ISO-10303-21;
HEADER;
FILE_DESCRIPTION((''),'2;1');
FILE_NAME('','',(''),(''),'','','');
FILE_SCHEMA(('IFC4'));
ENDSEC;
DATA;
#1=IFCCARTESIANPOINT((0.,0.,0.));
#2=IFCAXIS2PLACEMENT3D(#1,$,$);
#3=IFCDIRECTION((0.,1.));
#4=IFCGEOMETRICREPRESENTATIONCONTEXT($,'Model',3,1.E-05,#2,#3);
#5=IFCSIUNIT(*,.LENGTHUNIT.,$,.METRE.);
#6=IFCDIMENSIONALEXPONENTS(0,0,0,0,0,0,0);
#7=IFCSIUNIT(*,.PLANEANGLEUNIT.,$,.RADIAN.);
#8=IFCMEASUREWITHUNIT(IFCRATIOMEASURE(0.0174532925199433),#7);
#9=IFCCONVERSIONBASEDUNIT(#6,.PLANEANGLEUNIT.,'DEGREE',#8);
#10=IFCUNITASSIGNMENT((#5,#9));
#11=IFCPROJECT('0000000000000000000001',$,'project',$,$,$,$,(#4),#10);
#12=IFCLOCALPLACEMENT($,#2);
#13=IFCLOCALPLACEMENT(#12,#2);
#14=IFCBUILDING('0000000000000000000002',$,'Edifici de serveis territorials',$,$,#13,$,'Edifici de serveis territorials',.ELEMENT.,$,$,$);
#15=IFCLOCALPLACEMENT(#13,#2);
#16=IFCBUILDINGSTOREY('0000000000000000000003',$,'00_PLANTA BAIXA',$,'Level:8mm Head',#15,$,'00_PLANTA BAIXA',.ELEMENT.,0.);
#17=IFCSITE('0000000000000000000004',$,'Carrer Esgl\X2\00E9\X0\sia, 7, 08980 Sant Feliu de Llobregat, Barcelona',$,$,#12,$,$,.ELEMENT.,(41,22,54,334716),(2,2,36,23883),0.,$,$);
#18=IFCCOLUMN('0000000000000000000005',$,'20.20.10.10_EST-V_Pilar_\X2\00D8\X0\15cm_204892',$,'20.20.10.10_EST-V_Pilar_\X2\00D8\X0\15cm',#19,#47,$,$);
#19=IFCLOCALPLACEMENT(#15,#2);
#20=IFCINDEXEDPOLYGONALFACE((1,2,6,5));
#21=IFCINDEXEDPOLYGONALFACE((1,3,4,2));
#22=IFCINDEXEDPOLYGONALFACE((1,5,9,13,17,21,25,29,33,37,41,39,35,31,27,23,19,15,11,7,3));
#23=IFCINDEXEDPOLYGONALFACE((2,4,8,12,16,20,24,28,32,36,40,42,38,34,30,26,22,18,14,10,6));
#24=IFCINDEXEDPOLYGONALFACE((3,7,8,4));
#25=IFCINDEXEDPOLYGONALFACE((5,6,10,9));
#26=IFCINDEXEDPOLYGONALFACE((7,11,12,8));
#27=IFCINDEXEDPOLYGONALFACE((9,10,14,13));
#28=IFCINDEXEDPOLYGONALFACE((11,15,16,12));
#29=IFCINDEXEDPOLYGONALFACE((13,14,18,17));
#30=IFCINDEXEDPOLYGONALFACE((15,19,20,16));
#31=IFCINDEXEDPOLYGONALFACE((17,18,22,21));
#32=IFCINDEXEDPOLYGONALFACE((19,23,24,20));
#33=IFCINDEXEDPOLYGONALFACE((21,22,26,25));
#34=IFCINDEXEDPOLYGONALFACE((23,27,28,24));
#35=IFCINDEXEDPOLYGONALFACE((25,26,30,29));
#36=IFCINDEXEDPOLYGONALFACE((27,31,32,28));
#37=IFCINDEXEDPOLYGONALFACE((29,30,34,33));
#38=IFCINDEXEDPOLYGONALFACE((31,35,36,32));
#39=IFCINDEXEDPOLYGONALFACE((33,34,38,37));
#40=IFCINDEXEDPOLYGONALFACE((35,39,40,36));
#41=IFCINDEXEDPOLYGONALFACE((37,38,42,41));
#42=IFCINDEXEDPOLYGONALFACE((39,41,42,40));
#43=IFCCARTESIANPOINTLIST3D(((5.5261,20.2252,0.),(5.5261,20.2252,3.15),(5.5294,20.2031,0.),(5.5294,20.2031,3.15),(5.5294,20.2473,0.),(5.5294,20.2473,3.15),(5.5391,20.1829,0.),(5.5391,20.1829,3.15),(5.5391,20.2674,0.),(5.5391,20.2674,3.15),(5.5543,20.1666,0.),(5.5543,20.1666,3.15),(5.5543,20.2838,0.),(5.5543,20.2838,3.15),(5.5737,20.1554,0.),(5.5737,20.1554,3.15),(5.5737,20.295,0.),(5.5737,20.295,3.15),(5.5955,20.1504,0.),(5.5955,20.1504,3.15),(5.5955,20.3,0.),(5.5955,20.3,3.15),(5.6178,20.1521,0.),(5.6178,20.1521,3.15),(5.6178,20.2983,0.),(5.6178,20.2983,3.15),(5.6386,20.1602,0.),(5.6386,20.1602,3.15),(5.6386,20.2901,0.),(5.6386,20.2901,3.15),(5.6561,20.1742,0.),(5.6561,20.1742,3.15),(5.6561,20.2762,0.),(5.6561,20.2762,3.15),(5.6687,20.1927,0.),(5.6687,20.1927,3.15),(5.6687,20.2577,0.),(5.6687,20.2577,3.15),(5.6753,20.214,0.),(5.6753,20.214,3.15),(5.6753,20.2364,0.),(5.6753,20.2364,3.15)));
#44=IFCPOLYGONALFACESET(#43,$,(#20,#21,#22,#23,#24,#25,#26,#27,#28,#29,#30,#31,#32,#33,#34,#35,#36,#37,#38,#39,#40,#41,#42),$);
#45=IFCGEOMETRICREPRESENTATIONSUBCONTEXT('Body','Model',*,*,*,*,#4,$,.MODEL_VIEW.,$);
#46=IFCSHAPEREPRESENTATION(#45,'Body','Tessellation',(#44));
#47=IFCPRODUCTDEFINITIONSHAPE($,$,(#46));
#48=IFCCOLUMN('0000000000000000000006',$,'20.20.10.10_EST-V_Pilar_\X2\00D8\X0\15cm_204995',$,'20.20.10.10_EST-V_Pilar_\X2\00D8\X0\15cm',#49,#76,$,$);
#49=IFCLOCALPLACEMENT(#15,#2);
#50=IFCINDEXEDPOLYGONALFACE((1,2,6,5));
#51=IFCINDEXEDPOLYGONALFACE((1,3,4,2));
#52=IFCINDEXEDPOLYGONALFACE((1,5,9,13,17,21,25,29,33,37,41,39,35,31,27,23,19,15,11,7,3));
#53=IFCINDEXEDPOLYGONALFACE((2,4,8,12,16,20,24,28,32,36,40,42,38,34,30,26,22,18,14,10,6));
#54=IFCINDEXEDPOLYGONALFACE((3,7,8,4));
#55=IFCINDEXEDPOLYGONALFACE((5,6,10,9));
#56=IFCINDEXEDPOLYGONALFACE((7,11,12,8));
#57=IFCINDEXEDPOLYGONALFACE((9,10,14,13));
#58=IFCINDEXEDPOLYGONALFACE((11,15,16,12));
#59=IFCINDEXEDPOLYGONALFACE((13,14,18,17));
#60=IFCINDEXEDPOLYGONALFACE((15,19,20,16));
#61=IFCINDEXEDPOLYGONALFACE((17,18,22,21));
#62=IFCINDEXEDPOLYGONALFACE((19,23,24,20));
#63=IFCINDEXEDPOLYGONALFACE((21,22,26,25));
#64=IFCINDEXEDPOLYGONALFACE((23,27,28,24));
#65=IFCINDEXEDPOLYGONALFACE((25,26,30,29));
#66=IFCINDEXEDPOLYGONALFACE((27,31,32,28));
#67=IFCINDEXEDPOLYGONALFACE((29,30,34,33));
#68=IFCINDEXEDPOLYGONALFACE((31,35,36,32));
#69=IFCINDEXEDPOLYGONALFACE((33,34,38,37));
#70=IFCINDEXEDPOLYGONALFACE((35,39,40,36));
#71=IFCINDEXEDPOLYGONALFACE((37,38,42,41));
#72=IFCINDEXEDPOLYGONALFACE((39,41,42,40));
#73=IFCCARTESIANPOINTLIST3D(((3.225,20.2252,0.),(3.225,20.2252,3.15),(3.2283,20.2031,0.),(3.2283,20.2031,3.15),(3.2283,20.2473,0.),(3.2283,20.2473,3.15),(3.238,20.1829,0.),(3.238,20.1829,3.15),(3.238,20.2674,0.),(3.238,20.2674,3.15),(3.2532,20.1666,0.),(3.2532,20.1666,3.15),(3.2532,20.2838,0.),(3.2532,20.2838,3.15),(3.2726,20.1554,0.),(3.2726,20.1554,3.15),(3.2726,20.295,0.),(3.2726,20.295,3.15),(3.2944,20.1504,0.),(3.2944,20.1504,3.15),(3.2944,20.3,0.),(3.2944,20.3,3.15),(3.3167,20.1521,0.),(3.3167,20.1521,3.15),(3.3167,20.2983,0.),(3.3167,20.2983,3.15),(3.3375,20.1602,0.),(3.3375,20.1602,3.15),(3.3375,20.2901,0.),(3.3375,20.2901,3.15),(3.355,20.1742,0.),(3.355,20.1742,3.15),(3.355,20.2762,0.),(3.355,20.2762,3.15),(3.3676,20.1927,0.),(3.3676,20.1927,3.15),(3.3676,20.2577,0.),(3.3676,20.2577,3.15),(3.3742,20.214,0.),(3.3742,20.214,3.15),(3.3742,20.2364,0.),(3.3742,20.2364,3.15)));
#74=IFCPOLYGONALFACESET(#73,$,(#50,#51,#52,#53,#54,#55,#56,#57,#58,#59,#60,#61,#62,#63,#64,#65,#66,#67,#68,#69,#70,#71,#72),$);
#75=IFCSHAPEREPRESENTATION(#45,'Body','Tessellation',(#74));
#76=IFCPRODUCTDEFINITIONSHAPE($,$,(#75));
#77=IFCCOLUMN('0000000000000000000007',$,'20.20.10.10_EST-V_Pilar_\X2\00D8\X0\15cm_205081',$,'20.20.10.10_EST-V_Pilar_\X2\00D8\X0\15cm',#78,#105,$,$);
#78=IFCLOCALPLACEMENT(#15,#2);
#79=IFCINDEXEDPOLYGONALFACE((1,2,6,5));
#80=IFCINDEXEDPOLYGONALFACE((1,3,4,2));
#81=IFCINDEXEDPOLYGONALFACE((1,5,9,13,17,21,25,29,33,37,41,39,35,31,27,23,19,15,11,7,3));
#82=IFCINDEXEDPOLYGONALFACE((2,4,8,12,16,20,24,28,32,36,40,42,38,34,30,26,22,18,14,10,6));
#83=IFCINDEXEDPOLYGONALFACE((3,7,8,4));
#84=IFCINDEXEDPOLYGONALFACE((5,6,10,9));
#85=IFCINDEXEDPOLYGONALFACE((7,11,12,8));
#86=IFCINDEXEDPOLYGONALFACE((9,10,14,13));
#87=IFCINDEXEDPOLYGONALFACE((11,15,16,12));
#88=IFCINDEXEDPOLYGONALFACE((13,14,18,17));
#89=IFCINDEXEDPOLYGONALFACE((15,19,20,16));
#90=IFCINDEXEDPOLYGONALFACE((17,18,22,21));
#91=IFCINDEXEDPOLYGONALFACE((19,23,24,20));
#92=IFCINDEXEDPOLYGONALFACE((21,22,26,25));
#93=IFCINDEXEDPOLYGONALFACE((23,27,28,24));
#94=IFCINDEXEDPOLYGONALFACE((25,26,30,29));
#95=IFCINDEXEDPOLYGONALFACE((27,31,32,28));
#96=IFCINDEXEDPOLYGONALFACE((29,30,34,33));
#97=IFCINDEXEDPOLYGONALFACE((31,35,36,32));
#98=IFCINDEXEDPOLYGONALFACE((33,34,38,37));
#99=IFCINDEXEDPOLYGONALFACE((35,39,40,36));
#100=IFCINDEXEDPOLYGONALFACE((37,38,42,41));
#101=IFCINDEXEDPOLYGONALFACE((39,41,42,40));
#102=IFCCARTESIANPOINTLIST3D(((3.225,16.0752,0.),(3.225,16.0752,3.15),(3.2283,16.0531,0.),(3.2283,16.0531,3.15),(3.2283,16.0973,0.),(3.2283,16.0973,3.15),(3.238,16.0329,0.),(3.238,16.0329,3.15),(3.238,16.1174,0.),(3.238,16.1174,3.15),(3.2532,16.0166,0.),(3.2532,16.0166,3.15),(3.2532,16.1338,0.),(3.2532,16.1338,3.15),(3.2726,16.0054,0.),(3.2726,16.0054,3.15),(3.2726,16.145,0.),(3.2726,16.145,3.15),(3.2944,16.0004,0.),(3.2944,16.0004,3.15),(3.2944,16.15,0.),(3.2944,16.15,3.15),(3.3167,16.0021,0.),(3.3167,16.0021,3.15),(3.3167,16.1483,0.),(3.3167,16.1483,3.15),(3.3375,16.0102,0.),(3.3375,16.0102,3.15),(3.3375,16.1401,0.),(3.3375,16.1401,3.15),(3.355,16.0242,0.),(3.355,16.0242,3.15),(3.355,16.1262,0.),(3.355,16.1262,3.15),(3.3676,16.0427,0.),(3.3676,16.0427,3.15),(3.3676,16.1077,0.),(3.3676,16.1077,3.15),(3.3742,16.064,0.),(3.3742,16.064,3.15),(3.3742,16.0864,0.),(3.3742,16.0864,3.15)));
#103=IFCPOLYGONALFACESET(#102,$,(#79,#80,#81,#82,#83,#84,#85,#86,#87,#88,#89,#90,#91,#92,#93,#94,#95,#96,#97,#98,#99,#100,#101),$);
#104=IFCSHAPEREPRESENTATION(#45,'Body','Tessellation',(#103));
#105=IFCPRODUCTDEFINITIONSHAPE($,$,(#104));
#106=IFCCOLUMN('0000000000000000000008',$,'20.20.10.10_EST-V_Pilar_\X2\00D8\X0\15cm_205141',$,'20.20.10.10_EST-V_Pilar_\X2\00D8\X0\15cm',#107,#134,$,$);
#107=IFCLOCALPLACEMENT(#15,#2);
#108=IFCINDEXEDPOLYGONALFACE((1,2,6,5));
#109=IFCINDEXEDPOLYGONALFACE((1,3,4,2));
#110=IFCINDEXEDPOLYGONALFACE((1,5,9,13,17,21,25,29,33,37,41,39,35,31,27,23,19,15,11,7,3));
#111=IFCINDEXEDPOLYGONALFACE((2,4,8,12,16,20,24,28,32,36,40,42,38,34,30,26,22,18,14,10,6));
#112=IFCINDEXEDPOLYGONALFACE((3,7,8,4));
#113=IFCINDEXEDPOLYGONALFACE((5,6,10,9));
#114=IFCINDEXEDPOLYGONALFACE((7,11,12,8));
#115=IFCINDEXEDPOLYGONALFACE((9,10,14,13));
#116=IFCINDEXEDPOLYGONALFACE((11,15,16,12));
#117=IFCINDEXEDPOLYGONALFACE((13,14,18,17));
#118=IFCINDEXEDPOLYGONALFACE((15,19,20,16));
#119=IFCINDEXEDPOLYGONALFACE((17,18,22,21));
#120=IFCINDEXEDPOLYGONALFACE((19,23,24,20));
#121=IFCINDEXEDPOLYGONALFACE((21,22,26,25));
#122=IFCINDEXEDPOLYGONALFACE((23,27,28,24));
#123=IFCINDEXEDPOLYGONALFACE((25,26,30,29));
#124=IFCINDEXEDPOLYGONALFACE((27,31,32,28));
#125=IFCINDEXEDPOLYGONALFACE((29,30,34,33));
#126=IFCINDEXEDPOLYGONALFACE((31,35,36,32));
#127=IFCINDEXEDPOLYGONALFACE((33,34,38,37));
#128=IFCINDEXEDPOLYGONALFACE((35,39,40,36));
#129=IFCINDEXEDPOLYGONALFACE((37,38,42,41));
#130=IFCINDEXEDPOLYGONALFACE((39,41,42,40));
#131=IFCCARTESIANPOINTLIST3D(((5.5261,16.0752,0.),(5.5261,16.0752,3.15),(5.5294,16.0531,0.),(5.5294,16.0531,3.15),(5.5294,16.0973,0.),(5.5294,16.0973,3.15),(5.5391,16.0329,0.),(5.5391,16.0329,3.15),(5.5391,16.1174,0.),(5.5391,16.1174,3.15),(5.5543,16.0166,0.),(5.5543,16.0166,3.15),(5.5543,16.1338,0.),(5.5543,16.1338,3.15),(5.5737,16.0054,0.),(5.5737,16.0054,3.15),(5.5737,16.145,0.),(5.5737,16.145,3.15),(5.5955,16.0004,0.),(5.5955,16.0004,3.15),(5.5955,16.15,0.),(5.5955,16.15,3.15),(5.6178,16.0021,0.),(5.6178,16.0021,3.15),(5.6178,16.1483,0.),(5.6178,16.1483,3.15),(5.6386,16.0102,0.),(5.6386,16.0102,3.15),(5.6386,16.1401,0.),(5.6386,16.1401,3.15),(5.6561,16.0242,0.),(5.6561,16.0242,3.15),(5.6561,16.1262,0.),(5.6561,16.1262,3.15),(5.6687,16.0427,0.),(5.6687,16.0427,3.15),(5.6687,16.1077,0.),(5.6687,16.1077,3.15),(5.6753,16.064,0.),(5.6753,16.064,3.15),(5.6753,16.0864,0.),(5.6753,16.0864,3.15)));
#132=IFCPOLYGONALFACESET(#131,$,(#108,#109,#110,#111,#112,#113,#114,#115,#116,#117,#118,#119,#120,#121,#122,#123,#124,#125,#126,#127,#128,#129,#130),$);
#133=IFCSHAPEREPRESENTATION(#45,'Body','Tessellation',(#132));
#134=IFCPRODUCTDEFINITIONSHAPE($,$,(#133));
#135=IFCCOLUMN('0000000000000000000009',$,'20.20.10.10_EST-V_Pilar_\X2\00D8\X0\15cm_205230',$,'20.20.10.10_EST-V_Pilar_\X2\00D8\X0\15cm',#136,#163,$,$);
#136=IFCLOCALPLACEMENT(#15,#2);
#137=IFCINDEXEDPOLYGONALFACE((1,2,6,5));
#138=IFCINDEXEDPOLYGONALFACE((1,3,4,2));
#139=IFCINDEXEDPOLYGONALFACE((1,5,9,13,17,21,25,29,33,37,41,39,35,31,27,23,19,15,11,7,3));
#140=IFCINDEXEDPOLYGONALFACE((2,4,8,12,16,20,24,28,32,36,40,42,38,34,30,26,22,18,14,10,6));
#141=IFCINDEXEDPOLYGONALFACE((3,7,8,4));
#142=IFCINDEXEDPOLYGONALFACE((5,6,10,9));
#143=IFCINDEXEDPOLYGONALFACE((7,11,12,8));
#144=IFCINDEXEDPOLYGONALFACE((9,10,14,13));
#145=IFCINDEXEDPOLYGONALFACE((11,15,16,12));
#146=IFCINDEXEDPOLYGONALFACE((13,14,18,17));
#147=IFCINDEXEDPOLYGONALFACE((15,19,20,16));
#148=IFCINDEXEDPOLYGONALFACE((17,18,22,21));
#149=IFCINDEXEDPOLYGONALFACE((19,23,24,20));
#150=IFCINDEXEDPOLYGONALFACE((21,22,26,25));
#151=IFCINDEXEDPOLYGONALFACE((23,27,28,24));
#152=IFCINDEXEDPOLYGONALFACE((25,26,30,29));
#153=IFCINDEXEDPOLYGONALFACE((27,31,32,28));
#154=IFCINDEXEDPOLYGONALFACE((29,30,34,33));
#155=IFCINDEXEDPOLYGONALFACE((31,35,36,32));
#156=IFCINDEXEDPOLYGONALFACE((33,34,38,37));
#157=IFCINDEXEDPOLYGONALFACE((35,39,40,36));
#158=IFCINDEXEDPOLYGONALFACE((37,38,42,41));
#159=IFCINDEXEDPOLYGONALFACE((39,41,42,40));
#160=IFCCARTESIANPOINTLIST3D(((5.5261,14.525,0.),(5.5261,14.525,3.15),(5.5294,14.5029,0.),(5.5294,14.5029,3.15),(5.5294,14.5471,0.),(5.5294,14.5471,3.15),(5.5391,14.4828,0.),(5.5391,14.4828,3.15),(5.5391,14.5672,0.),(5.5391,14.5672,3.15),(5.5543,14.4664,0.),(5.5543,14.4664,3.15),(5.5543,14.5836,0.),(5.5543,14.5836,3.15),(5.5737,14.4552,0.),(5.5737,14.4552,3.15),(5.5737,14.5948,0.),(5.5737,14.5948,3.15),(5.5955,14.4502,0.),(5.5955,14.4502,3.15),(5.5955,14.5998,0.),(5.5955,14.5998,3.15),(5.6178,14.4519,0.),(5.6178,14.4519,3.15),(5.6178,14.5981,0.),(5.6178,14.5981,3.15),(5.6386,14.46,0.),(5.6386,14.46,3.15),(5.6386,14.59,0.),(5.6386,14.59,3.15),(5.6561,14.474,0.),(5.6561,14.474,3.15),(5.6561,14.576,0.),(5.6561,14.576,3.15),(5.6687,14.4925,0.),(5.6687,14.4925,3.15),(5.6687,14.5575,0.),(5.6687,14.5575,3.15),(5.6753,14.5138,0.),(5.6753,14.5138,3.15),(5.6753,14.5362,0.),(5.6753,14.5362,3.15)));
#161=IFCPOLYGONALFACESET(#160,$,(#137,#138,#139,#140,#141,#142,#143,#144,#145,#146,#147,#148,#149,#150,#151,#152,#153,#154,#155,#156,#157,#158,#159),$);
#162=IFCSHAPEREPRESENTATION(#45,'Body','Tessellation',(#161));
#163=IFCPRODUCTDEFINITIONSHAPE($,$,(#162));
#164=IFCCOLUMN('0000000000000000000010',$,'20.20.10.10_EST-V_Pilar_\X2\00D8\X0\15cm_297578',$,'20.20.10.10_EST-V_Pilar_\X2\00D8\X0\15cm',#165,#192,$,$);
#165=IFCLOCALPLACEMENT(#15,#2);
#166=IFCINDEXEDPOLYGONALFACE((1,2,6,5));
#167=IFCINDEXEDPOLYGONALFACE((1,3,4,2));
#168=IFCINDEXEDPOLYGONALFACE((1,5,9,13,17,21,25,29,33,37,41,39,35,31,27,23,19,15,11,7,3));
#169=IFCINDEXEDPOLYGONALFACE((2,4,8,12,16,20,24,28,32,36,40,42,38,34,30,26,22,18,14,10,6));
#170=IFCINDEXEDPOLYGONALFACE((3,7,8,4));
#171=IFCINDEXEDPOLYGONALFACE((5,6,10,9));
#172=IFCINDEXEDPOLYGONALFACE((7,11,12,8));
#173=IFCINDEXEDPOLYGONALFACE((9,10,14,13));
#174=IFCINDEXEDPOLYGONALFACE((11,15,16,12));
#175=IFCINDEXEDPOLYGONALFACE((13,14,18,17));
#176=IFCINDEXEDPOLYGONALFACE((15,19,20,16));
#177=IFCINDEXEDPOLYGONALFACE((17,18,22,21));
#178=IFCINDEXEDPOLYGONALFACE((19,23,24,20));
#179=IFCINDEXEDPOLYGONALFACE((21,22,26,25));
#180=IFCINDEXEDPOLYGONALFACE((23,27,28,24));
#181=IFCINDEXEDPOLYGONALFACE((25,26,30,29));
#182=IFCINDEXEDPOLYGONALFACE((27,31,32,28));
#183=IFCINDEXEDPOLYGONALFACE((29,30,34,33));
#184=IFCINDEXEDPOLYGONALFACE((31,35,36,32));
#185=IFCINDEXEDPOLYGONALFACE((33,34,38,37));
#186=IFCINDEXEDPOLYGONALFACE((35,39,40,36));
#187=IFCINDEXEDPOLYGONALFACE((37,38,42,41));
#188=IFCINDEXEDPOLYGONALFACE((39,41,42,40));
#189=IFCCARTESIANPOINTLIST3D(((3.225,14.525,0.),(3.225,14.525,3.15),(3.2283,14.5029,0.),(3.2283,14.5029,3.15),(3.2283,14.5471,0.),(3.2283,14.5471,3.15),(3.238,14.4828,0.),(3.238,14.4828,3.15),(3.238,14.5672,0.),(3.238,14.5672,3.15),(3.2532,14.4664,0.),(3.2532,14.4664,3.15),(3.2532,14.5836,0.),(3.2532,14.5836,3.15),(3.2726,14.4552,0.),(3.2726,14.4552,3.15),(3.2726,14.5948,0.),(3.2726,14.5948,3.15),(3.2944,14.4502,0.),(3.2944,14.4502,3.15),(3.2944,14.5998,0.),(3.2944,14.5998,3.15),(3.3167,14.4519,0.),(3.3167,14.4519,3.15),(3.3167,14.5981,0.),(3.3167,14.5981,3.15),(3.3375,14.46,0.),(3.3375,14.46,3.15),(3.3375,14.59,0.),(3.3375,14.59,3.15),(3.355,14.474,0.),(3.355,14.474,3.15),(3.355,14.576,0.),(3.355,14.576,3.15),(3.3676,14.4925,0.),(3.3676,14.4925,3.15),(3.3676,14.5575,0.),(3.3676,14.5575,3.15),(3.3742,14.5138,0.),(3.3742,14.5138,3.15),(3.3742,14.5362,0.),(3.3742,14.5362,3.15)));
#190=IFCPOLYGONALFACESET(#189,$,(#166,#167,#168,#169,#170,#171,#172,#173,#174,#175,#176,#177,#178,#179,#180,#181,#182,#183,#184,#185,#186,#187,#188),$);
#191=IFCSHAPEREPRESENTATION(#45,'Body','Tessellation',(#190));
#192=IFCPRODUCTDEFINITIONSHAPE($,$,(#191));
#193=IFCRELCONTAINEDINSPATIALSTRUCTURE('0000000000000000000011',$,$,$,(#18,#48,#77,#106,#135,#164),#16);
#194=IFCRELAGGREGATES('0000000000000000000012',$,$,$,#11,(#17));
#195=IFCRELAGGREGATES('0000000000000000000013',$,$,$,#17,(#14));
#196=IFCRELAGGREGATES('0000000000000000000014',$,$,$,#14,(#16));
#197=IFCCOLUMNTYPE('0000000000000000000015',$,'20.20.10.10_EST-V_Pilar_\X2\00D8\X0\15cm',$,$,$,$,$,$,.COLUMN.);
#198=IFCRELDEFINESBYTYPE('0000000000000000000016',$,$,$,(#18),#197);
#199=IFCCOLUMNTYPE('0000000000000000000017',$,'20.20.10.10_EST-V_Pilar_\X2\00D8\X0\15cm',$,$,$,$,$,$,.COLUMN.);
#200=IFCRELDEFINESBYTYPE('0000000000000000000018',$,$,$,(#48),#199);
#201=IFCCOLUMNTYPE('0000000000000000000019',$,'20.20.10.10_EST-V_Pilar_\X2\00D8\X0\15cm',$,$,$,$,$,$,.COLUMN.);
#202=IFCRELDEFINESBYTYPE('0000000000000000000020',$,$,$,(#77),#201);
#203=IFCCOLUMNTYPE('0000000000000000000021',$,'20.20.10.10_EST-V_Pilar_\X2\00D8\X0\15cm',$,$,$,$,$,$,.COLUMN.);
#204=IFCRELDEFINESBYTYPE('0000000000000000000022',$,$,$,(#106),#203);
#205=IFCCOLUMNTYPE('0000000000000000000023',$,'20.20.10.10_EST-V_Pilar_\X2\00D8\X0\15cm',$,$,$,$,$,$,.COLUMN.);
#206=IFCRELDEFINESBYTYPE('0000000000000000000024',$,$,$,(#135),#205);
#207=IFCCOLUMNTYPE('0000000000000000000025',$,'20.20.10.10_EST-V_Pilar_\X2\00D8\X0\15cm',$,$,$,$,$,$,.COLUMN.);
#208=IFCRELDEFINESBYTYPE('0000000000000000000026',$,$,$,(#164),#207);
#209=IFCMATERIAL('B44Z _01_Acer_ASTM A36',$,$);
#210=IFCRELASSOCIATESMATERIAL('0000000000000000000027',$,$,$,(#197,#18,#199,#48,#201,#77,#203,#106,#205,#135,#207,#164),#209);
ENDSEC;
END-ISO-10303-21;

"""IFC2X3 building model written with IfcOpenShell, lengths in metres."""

from ifc_helpers import new_model, entity, si_unit, converted_unit, direction, frame, origin, origin_2d_with_axis, place, context, subcontext, project, spatial, circle, extrude, source, transform, mapped, material, type_object, type_shapes, element, save


model = new_model("IFC2X3")

# Units and contexts
model_context = context("Model", 3, precision=1e-05, world=origin(), true_north=direction((0.0, 1.0)))
body_context = subcontext(model_context, "Body", "Model", "MODEL_VIEW")
ifc_project = project(units=[si_unit("LENGTHUNIT", "METRE"), converted_unit("PLANEANGLEUNIT", "DEGREE", entity("IfcRatioMeasure", 0.0174532925199433), si_unit("PLANEANGLEUNIT", "RADIAN"), dimensions=[0, 0, 0, 0, 0, 0, 0])], contexts=[model_context])

# Site, building, storey
site_placement = place(None, origin())
site = spatial("IfcSite", under=ifc_project, at=site_placement, Name="Carrer Església, 7, 08980 Sant Feliu de Llobregat, Barcelona", CompositionType="ELEMENT", RefLatitude=(41, 22, 54, 334716), RefLongitude=(2, 2, 36, 23883), RefElevation=0.0)
building_placement = place(site_placement, origin())
building = spatial("IfcBuilding", under=site, at=building_placement, Name="Edifici de serveis territorials", LongName="Edifici de serveis territorials", CompositionType="ELEMENT")
storey_placement = place(building_placement, origin())
storey = spatial("IfcBuildingStorey", under=building, at=storey_placement, Name="00_PLANTA BAIXA", ObjectType="Level:8mm Head", LongName="00_PLANTA BAIXA", CompositionType="ELEMENT", Elevation=0.0)

# Columns
ifc_material_1 = material(Name="B44Z _01_Acer_ASTM A36")
column_type_1 = type_object("IfcColumnType", Name="20.20.10.10_EST-V_Pilar_Ø15cm", PredefinedType="COLUMN", material=ifc_material_1)
shared_shape_1 = source(origin(), body_context, "Body", "SweptSolid", [
    extrude(circle(Radius=0.075, at=origin_2d_with_axis()), frame((5.6011, 20.2252, 0.0), z_axis=(0.0, 0.0, 1.0), x_axis=(-1.0, 0.0, 0.0)), (0.0, 0.0, 1.0), 3.15),
])
type_shapes(column_type_1, [shared_shape_1])
column_1_placement = place(storey_placement, origin())
element("IfcColumn", 1, at=column_1_placement, inside=storey, type_object=column_type_1, material=ifc_material_1, Name="20.20.10.10_EST-V_Pilar_Ø15cm_204892", ObjectType="20.20.10.10_EST-V_Pilar_Ø15cm", context=body_context, shape_type="MappedRepresentation", body=[
    mapped(shared_shape_1, transform((0.0, 0.0, 0.0), scale=1.0)),
])
column_type_2 = type_object("IfcColumnType", Name="20.20.10.10_EST-V_Pilar_Ø15cm", PredefinedType="COLUMN", material=ifc_material_1)
shared_shape_2 = source(origin(), body_context, "Body", "SweptSolid", [
    extrude(circle(Radius=0.075, at=origin_2d_with_axis()), frame((3.3, 20.2252, 0.0), z_axis=(0.0, 0.0, 1.0), x_axis=(-1.0, 0.0, 0.0)), (0.0, 0.0, 1.0), 3.15),
])
type_shapes(column_type_2, [shared_shape_2])
column_2_placement = place(storey_placement, origin())
element("IfcColumn", 2, at=column_2_placement, inside=storey, type_object=column_type_2, material=ifc_material_1, Name="20.20.10.10_EST-V_Pilar_Ø15cm_204995", ObjectType="20.20.10.10_EST-V_Pilar_Ø15cm", context=body_context, shape_type="MappedRepresentation", body=[
    mapped(shared_shape_2, transform((0.0, 0.0, 0.0), scale=1.0)),
])
column_type_3 = type_object("IfcColumnType", Name="20.20.10.10_EST-V_Pilar_Ø15cm", PredefinedType="COLUMN", material=ifc_material_1)
shared_shape_3 = source(origin(), body_context, "Body", "SweptSolid", [
    extrude(circle(Radius=0.075, at=origin_2d_with_axis()), frame((3.3, 16.0752, 0.0), z_axis=(0.0, 0.0, 1.0), x_axis=(-1.0, 0.0, 0.0)), (0.0, 0.0, 1.0), 3.15),
])
type_shapes(column_type_3, [shared_shape_3])
column_3_placement = place(storey_placement, origin())
element("IfcColumn", 3, at=column_3_placement, inside=storey, type_object=column_type_3, material=ifc_material_1, Name="20.20.10.10_EST-V_Pilar_Ø15cm_205081", ObjectType="20.20.10.10_EST-V_Pilar_Ø15cm", context=body_context, shape_type="MappedRepresentation", body=[
    mapped(shared_shape_3, transform((0.0, 0.0, 0.0), scale=1.0)),
])
column_type_4 = type_object("IfcColumnType", Name="20.20.10.10_EST-V_Pilar_Ø15cm", PredefinedType="COLUMN", material=ifc_material_1)
shared_shape_4 = source(origin(), body_context, "Body", "SweptSolid", [
    extrude(circle(Radius=0.075, at=origin_2d_with_axis()), frame((5.6011, 16.0752, 0.0), z_axis=(0.0, 0.0, 1.0), x_axis=(-1.0, 0.0, 0.0)), (0.0, 0.0, 1.0), 3.15),
])
type_shapes(column_type_4, [shared_shape_4])
column_4_placement = place(storey_placement, origin())
element("IfcColumn", 4, at=column_4_placement, inside=storey, type_object=column_type_4, material=ifc_material_1, Name="20.20.10.10_EST-V_Pilar_Ø15cm_205141", ObjectType="20.20.10.10_EST-V_Pilar_Ø15cm", context=body_context, shape_type="MappedRepresentation", body=[
    mapped(shared_shape_4, transform((0.0, 0.0, 0.0), scale=1.0)),
])
column_type_5 = type_object("IfcColumnType", Name="20.20.10.10_EST-V_Pilar_Ø15cm", PredefinedType="COLUMN", material=ifc_material_1)
shared_shape_5 = source(origin(), body_context, "Body", "SweptSolid", [
    extrude(circle(Radius=0.075, at=origin_2d_with_axis()), frame((5.6011, 14.525, 0.0), z_axis=(0.0, 0.0, 1.0), x_axis=(-1.0, 0.0, 0.0)), (0.0, 0.0, 1.0), 3.15),
])
type_shapes(column_type_5, [shared_shape_5])
column_5_placement = place(storey_placement, origin())
element("IfcColumn", 5, at=column_5_placement, inside=storey, type_object=column_type_5, material=ifc_material_1, Name="20.20.10.10_EST-V_Pilar_Ø15cm_205230", ObjectType="20.20.10.10_EST-V_Pilar_Ø15cm", context=body_context, shape_type="MappedRepresentation", body=[
    mapped(shared_shape_5, transform((0.0, 0.0, 0.0), scale=1.0)),
])
column_type_6 = type_object("IfcColumnType", Name="20.20.10.10_EST-V_Pilar_Ø15cm", PredefinedType="COLUMN", material=ifc_material_1)
shared_shape_6 = source(origin(), body_context, "Body", "SweptSolid", [
    extrude(circle(Radius=0.075, at=origin_2d_with_axis()), frame((3.3, 14.525, 0.0), z_axis=(0.0, 0.0, 1.0), x_axis=(-1.0, 0.0, 0.0)), (0.0, 0.0, 1.0), 3.15),
])
type_shapes(column_type_6, [shared_shape_6])
column_6_placement = place(storey_placement, origin())
element("IfcColumn", 6, at=column_6_placement, inside=storey, type_object=column_type_6, material=ifc_material_1, Name="20.20.10.10_EST-V_Pilar_Ø15cm_297578", ObjectType="20.20.10.10_EST-V_Pilar_Ø15cm", context=body_context, shape_type="MappedRepresentation", body=[
    mapped(shared_shape_6, transform((0.0, 0.0, 0.0), scale=1.0)),
])

save(model, "model.ifc")
